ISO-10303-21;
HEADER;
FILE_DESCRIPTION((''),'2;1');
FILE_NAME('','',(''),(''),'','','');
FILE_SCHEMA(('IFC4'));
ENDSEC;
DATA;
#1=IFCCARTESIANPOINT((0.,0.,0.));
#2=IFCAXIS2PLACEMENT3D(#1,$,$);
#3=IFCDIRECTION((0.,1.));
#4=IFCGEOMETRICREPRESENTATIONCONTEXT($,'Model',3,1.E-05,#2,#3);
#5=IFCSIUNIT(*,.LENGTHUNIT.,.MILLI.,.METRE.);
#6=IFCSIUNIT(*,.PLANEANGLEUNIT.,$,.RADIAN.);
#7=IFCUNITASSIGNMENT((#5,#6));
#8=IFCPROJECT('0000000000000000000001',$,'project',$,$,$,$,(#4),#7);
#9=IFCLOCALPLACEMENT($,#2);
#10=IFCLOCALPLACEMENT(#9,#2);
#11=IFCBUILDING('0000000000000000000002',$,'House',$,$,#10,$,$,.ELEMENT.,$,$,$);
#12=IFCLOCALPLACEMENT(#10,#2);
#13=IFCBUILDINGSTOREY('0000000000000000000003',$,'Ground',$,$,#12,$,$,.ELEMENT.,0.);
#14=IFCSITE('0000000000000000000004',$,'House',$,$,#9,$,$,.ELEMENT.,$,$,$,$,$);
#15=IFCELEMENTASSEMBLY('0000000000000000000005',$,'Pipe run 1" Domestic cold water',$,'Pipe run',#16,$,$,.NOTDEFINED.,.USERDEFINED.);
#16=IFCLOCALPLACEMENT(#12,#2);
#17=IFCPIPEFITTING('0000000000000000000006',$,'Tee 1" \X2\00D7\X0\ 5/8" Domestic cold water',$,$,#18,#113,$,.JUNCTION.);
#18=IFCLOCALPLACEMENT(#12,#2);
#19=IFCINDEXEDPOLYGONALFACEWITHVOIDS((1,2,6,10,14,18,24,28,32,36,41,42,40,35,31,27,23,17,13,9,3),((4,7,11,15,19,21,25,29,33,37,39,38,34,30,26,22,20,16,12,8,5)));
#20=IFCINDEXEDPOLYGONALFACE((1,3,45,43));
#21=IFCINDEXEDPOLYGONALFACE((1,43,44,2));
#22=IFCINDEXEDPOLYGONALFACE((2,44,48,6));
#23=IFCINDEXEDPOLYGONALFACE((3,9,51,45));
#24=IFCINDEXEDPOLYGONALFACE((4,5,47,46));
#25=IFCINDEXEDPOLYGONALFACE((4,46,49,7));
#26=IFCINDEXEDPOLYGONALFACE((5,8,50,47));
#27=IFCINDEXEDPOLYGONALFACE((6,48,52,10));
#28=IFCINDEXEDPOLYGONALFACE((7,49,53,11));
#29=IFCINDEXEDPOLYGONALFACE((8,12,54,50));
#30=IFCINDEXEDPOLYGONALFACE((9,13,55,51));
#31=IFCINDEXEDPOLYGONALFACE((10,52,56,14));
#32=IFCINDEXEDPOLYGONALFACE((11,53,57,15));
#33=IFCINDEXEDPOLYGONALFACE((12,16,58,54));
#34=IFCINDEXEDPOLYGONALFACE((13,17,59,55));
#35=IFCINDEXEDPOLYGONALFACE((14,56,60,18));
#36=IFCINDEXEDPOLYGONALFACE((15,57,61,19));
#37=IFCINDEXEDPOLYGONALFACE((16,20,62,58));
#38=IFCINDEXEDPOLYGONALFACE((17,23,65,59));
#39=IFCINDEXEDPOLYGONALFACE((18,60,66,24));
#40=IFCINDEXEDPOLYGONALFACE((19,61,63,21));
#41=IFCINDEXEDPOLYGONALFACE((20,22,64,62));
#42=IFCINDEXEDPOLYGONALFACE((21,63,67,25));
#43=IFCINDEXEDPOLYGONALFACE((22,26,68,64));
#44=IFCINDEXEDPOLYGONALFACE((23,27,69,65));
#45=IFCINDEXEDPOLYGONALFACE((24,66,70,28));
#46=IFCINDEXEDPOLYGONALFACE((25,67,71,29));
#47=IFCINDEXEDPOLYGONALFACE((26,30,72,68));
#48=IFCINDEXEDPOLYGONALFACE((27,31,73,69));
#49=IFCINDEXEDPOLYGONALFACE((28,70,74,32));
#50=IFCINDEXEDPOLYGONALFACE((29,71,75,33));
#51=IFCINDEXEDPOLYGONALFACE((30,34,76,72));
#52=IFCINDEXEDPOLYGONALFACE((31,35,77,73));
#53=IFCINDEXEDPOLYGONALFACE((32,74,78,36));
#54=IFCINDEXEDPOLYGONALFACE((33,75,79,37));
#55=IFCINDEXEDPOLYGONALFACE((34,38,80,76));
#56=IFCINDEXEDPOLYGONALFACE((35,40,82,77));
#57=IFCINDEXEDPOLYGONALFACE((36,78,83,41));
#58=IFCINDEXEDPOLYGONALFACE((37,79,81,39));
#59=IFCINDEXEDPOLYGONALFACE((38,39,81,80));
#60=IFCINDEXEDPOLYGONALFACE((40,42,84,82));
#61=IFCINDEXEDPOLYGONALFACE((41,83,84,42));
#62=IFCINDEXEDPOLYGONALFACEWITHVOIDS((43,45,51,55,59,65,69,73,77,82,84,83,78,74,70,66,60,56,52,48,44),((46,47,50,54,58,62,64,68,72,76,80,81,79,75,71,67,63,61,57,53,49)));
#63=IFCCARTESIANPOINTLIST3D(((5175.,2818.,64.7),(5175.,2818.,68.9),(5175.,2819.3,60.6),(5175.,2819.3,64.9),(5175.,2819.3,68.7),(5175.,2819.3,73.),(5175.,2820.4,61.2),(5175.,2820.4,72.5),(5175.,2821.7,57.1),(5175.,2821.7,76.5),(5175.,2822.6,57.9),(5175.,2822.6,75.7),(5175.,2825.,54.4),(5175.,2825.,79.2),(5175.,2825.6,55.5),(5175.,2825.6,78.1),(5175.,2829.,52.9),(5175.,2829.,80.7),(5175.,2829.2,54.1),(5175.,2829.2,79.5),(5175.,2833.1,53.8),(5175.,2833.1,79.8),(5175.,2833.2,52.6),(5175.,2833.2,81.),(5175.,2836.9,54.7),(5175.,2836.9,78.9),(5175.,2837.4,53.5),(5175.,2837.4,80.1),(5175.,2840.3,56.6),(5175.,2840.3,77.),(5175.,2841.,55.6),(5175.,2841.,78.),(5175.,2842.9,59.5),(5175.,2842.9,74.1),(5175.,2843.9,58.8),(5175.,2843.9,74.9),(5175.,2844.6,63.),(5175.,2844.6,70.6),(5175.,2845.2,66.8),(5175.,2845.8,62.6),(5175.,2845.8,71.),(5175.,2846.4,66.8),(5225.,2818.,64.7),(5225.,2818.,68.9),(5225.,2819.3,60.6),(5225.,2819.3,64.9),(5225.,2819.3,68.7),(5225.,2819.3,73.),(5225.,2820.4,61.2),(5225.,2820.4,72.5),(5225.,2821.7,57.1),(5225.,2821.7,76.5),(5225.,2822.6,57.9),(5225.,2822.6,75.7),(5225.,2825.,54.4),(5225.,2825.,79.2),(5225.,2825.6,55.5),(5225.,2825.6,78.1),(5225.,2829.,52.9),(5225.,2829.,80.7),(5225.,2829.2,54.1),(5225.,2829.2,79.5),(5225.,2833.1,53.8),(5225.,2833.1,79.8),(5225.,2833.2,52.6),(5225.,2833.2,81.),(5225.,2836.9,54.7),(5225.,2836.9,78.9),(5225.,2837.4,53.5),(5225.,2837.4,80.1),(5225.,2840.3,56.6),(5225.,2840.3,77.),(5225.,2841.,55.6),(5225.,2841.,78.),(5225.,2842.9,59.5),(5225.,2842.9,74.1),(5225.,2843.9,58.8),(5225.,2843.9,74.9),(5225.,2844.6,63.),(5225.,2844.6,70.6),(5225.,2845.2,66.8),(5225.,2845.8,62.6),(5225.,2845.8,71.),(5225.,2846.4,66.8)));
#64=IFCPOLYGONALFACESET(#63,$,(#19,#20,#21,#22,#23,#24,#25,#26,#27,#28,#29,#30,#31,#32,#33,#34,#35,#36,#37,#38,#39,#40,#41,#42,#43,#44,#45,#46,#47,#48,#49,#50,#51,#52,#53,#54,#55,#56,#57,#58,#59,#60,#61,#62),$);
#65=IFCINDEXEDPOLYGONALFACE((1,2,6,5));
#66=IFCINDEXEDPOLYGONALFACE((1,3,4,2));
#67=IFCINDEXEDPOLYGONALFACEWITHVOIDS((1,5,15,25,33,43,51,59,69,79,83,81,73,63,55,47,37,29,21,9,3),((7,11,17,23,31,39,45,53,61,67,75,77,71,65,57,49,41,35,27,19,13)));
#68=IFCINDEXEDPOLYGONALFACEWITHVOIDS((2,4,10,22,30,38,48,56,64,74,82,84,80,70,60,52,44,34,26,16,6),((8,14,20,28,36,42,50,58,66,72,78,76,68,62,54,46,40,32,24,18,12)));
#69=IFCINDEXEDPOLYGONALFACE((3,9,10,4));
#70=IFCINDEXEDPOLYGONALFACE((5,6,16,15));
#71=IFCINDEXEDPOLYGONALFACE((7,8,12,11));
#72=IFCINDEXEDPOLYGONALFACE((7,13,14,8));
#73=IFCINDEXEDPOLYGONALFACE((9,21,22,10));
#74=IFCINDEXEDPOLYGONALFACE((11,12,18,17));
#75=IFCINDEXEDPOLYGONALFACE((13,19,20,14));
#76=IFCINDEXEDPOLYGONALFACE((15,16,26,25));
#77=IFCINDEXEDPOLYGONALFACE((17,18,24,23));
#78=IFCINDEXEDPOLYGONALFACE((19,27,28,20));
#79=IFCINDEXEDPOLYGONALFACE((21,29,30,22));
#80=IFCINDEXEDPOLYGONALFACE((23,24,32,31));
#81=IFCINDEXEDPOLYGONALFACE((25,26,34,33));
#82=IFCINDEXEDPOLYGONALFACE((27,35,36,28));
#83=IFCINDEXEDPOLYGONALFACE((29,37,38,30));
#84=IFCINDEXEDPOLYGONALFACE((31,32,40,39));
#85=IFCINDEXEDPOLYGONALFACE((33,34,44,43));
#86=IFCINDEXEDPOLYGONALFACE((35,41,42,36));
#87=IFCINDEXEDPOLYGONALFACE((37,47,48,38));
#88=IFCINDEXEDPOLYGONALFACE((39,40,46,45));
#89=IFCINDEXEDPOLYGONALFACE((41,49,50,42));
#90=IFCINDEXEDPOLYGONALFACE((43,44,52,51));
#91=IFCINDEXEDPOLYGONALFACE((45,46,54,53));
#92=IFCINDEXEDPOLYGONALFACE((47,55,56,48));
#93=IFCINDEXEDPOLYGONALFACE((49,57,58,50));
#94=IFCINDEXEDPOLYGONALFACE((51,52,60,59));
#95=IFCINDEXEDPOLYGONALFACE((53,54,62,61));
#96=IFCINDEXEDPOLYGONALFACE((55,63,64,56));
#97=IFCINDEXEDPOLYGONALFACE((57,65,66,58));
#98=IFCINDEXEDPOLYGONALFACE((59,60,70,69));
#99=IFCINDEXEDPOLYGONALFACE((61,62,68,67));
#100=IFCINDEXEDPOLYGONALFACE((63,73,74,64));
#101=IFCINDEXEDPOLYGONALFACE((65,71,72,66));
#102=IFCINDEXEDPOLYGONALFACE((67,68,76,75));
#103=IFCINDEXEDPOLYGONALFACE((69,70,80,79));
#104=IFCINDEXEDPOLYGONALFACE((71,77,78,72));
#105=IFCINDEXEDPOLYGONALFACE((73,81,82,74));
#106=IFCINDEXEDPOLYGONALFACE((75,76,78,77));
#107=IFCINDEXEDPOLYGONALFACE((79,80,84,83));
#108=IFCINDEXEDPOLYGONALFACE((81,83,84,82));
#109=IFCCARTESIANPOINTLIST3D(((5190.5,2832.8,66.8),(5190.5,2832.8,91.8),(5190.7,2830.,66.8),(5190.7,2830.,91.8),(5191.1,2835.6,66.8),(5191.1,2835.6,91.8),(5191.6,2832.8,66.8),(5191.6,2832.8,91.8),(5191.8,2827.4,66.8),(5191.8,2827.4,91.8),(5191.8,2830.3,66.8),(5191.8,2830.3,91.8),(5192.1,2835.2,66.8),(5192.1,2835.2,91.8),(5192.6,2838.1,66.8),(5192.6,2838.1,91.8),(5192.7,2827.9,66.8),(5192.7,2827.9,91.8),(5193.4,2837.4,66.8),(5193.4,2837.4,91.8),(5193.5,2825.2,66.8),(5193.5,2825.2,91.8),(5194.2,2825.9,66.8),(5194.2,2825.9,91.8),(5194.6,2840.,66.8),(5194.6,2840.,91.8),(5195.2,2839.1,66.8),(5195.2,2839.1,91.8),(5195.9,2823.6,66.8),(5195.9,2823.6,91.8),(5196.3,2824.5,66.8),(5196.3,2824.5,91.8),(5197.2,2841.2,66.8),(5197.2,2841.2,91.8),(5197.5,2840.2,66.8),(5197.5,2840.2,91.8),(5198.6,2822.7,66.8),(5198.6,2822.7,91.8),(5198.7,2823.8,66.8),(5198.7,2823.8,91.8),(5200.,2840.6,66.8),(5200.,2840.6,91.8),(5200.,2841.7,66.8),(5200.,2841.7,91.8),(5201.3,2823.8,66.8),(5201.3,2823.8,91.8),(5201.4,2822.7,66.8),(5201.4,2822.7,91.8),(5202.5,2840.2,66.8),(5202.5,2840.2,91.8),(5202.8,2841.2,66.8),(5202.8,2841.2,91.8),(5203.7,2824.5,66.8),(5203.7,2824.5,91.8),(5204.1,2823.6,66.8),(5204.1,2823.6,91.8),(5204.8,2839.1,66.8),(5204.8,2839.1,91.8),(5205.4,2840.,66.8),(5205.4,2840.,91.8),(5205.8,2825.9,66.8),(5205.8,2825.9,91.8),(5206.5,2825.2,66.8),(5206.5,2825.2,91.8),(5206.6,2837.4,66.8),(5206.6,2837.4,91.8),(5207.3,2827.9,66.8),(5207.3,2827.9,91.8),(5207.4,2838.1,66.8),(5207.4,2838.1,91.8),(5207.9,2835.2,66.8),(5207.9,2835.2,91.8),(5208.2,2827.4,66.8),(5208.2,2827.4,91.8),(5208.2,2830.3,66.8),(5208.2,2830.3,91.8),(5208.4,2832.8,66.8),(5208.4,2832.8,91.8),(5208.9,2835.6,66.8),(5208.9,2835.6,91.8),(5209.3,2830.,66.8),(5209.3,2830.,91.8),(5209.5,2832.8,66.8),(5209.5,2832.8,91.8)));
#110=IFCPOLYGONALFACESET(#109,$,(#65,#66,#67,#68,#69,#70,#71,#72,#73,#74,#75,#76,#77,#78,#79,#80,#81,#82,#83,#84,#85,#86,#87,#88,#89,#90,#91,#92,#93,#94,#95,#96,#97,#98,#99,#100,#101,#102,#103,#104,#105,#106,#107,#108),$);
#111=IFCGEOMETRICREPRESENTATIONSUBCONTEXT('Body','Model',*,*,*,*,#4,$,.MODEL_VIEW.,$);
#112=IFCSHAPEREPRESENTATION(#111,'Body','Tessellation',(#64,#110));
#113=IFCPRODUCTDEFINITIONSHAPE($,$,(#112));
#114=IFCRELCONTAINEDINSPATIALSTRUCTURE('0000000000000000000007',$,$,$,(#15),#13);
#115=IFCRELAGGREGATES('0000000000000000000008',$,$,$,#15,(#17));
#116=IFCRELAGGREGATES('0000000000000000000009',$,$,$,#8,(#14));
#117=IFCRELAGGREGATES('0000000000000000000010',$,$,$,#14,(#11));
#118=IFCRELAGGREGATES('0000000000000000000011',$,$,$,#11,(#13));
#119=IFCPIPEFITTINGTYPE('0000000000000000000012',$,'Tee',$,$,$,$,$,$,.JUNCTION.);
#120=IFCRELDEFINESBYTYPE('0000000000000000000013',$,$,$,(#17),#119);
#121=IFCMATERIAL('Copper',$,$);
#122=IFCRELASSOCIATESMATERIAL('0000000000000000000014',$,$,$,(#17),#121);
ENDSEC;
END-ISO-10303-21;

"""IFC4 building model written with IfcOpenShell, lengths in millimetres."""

from ifc_helpers import new_model, si_unit, direction, frame, origin, origin_with_axes, origin_2d, place, context, subcontext, project, spatial, hollow_circle, extrude, material, type_object, element, aggregate, save


model = new_model("IFC4")

# Units and contexts
model_context = context("Model", 3, precision=1e-05, world=origin(), true_north=direction((0.0, 1.0)))
body_context = subcontext(model_context, "Body", "Model", "MODEL_VIEW")
ifc_project = project(units=[si_unit("LENGTHUNIT", "METRE", prefix="MILLI"), si_unit("PLANEANGLEUNIT", "RADIAN")], contexts=[model_context])

# Site, building, storey
site_placement = place(None, origin())
site = spatial("IfcSite", under=ifc_project, at=site_placement, Name="House", CompositionType="ELEMENT")
building_placement = place(site_placement, origin())
building = spatial("IfcBuilding", under=site, at=building_placement, Name="House", CompositionType="ELEMENT")
storey_placement = place(building_placement, origin())
storey = spatial("IfcBuildingStorey", under=building, at=storey_placement, Name="Ground", CompositionType="ELEMENT", Elevation=0.0)

# Shared definitions
ifc_material = material(Name="Copper")

# Element assembly
assembly_1_placement = place(storey_placement, origin_with_axes())
assembly_1 = element("IfcElementAssembly", 1, at=assembly_1_placement, inside=storey, Name="Pipe run 1\" Domestic cold water", ObjectType="Pipe run", AssemblyPlace="NOTDEFINED", PredefinedType="USERDEFINED")

# Pipe fitting
pipe_fitting_type_1 = type_object("IfcPipeFittingType", Name="Tee", PredefinedType="JUNCTION")
pipe_fitting_1_placement = place(storey_placement, origin_with_axes())
pipe_fitting_1 = element("IfcPipeFitting", 2, at=pipe_fitting_1_placement, type_object=pipe_fitting_type_1, material=ifc_material, Name="Tee 1\" × 5/8\" Domestic cold water", PredefinedType="JUNCTION", context=body_context, shape_type="SweptSolid", body=[
    extrude(hollow_circle(Radius=14.3, WallThickness=1.3, at=origin_2d()), frame((5175.0, 2832.1, 66.8), z_axis=(1.0, 0.0, 0.0), x_axis=(0.0, 1.0, 0.0)), (0.0, 0.0, 1.0), 50.0),
    extrude(hollow_circle(Radius=9.5, WallThickness=1.1, at=origin_2d()), frame((5200.0, 2832.1, 66.8), z_axis=(0.0, 0.0, 1.0), x_axis=(0.0, 1.0, 0.0)), (0.0, 0.0, 1.0), 25.0),
])
aggregate(assembly_1, [pipe_fitting_1])

save(model, "model.ifc")
